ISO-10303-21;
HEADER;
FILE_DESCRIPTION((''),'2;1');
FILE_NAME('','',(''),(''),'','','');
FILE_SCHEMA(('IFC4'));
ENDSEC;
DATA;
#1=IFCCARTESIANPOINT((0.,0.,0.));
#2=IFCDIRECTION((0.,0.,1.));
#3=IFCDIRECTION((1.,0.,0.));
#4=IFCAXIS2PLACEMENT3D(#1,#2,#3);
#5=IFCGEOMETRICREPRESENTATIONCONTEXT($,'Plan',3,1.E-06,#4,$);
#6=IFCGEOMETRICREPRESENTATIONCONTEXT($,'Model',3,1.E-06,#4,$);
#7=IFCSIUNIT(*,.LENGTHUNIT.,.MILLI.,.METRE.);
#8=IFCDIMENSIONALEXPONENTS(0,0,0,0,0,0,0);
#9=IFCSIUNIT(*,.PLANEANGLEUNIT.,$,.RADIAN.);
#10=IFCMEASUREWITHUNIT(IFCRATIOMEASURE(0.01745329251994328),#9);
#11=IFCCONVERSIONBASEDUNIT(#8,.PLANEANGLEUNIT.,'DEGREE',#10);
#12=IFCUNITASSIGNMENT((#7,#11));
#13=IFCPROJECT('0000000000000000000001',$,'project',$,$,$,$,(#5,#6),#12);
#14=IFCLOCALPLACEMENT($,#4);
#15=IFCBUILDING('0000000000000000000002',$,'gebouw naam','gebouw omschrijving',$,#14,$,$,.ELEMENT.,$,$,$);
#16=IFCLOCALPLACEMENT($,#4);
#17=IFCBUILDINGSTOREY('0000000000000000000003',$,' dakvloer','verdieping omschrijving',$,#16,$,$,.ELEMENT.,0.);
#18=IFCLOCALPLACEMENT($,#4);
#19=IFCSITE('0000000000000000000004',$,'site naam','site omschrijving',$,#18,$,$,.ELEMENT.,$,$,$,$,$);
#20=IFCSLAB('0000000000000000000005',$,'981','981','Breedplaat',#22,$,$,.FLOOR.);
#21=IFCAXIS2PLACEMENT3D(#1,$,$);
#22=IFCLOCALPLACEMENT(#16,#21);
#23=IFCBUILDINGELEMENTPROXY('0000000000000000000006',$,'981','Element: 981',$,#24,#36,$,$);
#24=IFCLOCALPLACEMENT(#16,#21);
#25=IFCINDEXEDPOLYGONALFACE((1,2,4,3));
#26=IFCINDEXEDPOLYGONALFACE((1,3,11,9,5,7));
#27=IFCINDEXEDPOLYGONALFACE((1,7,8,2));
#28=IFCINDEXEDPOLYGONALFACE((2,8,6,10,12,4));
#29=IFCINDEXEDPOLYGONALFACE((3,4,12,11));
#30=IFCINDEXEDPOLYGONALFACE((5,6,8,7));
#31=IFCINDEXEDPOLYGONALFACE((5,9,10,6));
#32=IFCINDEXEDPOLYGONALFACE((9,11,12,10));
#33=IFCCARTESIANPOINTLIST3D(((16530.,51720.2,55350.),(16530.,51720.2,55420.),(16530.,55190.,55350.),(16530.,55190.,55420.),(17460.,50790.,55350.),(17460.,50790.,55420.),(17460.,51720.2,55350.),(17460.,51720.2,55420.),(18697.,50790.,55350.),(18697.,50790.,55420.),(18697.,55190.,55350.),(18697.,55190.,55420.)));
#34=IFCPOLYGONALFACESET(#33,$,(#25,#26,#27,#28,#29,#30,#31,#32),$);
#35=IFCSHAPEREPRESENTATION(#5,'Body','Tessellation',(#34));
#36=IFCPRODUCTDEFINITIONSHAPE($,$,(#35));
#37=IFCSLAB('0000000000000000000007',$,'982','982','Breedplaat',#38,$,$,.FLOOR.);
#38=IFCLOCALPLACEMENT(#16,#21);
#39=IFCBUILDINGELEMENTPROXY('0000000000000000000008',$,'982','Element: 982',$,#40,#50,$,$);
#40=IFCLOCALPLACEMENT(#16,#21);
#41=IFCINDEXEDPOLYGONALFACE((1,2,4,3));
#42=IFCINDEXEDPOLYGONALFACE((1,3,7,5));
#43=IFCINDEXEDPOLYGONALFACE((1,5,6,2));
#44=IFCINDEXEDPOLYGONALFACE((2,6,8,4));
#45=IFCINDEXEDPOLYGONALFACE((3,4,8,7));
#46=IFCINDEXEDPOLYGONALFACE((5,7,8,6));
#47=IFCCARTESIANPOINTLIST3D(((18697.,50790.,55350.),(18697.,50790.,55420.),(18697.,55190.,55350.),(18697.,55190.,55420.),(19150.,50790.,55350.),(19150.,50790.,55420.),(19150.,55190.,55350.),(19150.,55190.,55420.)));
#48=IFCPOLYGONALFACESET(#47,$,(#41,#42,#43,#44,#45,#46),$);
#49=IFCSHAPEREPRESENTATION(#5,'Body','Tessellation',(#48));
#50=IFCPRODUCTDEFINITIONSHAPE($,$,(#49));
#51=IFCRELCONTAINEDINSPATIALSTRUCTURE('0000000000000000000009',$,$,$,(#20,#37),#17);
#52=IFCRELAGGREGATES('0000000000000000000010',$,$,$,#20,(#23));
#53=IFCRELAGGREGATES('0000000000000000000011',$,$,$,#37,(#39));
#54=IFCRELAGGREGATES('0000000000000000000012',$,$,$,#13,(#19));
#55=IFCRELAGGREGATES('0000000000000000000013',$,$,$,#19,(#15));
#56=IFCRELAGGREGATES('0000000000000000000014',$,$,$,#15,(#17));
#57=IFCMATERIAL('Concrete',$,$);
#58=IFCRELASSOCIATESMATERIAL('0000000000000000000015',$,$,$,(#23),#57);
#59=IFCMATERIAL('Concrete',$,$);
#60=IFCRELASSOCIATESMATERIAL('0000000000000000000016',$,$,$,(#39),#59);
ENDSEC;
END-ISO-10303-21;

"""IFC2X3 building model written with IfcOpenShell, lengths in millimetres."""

from ifc_helpers import new_model, entity, si_unit, converted_unit, frame, origin_with_axes, origin_2d_with_axis, place, context, project, spatial, polyline, circle, outline, extrude, material, element, aggregate, save


model = new_model("IFC2X3")

# Units and contexts
plan_context = context("Plan", 3, precision=1e-06, world=origin_with_axes())
model_context = context("Model", 3, precision=1e-06, world=origin_with_axes())
ifc_project = project(units=[si_unit("LENGTHUNIT", "METRE", prefix="MILLI"), converted_unit("PLANEANGLEUNIT", "DEGREE", entity("IfcRatioMeasure", 0.01745329251994328), si_unit("PLANEANGLEUNIT", "RADIAN"), dimensions=[0, 0, 0, 0, 0, 0, 0])], contexts=[plan_context, model_context])

# Site, building, storey
site_placement = place(None, origin_with_axes())
site = spatial("IfcSite", under=ifc_project, at=site_placement, Name="site naam", Description="site omschrijving", CompositionType="ELEMENT")
building_placement = place(None, origin_with_axes())
building = spatial("IfcBuilding", under=site, at=building_placement, Name="gebouw naam", Description="gebouw omschrijving", CompositionType="ELEMENT")
storey_placement = place(None, origin_with_axes())
storey = spatial("IfcBuildingStorey", under=building, at=storey_placement, Name=" dakvloer", Description="verdieping omschrijving", CompositionType="ELEMENT", Elevation=0.0)

# Slab, building element proxy, openings
slab_1_placement = place(None, frame((16530.0, 55190.0, 55350.0), z_axis=(0.0, 0.0, 1.0), x_axis=(0.0, -1.0, 0.0)))
slab_1 = element("IfcSlab", 1, at=slab_1_placement, inside=storey, Name="981", Description="981", ObjectType="Breedplaat", PredefinedType="FLOOR")
ifc_material_1 = material(Name="Concrete")
proxy_1_placement = place(slab_1_placement, origin_with_axes())
proxy_1 = element("IfcBuildingElementProxy", 2, at=proxy_1_placement, material=ifc_material_1, Name="981", Description="Element: 981", context=plan_context, shape_type="SweptSolid", body=[
    extrude(outline(polyline([(3469.8, 0.0), (3469.8, 930.0), (4400.0, 930.0), (4400.0, 2167.0), (0.0, 2167.0), (0.0, 0.0), (3469.8, 0.0)])), origin_with_axes(), (0.0, 0.0, 1.0), 70.0),
])
opening_1_placement = place(slab_1_placement, frame((510.0, 1310.0, 0.0), z_axis=(0.0, 0.0, 1.0), x_axis=(1.0, 0.0, 0.0)))
element("IfcOpeningElement", 3, at=opening_1_placement, cuts=proxy_1, ObjectType="Opening", context=plan_context, shape_type="SolidModel", body=[
    extrude(circle(Radius=125.0, at=origin_2d_with_axis()), origin_with_axes(), (0.0, 0.0, 1.0), 70.0),
])
opening_2_placement = place(None, frame((16530.0, 55190.0, 55350.0), z_axis=(0.0, 0.0, 1.0), x_axis=(0.0, -1.0, 0.0)))
element("IfcOpeningElement", 4, at=opening_2_placement, cuts=proxy_1, ObjectType="Opening", context=plan_context, shape_type="SweptSolid", body=[
    extrude(outline(polyline([(-0.1, -0.1), (-0.1, 10.0), (10.0, -0.1), (-0.1, -0.1)])), frame((4401.2, 2167.2, -0.1), z_axis=(-1.0, 0.0, 0.0), x_axis=(0.0, -1.0, 0.0)), (0.0, 0.0, 1.0), 4402.2),
])
aggregate(slab_1, [proxy_1])

# Slab, building element proxy, opening
slab_2_placement = place(None, frame((18697.0, 55190.0, 55350.0), z_axis=(0.0, 0.0, 1.0), x_axis=(0.0, -1.0, 0.0)))
slab_2 = element("IfcSlab", 5, at=slab_2_placement, inside=storey, Name="982", Description="982", ObjectType="Breedplaat", PredefinedType="FLOOR")
ifc_material_2 = material(Name="Concrete")
proxy_2_placement = place(slab_2_placement, origin_with_axes())
proxy_2 = element("IfcBuildingElementProxy", 6, at=proxy_2_placement, material=ifc_material_2, Name="982", Description="Element: 982", context=plan_context, shape_type="SweptSolid", body=[
    extrude(outline(polyline([(4400.0, 0.0), (4400.0, 453.0), (0.0, 453.0), (0.0, 0.0), (4400.0, 0.0)])), origin_with_axes(), (0.0, 0.0, 1.0), 70.0),
])
opening_3_placement = place(None, frame((18697.0, 55190.0, 55350.0), z_axis=(0.0, 0.0, 1.0), x_axis=(0.0, -1.0, 0.0)))
element("IfcOpeningElement", 7, at=opening_3_placement, cuts=proxy_2, ObjectType="Opening", context=plan_context, shape_type="SweptSolid", body=[
    extrude(outline(polyline([(-0.1, -0.1), (-0.1, 10.0), (10.0, -0.1), (-0.1, -0.1)])), frame((-1.2, -0.1, -0.1), z_axis=(1.0, 0.0, 0.0), x_axis=(0.0, 1.0, 0.0)), (0.0, 0.0, 1.0), 4402.2),
])
aggregate(slab_2, [proxy_2])

save(model, "model.ifc")
